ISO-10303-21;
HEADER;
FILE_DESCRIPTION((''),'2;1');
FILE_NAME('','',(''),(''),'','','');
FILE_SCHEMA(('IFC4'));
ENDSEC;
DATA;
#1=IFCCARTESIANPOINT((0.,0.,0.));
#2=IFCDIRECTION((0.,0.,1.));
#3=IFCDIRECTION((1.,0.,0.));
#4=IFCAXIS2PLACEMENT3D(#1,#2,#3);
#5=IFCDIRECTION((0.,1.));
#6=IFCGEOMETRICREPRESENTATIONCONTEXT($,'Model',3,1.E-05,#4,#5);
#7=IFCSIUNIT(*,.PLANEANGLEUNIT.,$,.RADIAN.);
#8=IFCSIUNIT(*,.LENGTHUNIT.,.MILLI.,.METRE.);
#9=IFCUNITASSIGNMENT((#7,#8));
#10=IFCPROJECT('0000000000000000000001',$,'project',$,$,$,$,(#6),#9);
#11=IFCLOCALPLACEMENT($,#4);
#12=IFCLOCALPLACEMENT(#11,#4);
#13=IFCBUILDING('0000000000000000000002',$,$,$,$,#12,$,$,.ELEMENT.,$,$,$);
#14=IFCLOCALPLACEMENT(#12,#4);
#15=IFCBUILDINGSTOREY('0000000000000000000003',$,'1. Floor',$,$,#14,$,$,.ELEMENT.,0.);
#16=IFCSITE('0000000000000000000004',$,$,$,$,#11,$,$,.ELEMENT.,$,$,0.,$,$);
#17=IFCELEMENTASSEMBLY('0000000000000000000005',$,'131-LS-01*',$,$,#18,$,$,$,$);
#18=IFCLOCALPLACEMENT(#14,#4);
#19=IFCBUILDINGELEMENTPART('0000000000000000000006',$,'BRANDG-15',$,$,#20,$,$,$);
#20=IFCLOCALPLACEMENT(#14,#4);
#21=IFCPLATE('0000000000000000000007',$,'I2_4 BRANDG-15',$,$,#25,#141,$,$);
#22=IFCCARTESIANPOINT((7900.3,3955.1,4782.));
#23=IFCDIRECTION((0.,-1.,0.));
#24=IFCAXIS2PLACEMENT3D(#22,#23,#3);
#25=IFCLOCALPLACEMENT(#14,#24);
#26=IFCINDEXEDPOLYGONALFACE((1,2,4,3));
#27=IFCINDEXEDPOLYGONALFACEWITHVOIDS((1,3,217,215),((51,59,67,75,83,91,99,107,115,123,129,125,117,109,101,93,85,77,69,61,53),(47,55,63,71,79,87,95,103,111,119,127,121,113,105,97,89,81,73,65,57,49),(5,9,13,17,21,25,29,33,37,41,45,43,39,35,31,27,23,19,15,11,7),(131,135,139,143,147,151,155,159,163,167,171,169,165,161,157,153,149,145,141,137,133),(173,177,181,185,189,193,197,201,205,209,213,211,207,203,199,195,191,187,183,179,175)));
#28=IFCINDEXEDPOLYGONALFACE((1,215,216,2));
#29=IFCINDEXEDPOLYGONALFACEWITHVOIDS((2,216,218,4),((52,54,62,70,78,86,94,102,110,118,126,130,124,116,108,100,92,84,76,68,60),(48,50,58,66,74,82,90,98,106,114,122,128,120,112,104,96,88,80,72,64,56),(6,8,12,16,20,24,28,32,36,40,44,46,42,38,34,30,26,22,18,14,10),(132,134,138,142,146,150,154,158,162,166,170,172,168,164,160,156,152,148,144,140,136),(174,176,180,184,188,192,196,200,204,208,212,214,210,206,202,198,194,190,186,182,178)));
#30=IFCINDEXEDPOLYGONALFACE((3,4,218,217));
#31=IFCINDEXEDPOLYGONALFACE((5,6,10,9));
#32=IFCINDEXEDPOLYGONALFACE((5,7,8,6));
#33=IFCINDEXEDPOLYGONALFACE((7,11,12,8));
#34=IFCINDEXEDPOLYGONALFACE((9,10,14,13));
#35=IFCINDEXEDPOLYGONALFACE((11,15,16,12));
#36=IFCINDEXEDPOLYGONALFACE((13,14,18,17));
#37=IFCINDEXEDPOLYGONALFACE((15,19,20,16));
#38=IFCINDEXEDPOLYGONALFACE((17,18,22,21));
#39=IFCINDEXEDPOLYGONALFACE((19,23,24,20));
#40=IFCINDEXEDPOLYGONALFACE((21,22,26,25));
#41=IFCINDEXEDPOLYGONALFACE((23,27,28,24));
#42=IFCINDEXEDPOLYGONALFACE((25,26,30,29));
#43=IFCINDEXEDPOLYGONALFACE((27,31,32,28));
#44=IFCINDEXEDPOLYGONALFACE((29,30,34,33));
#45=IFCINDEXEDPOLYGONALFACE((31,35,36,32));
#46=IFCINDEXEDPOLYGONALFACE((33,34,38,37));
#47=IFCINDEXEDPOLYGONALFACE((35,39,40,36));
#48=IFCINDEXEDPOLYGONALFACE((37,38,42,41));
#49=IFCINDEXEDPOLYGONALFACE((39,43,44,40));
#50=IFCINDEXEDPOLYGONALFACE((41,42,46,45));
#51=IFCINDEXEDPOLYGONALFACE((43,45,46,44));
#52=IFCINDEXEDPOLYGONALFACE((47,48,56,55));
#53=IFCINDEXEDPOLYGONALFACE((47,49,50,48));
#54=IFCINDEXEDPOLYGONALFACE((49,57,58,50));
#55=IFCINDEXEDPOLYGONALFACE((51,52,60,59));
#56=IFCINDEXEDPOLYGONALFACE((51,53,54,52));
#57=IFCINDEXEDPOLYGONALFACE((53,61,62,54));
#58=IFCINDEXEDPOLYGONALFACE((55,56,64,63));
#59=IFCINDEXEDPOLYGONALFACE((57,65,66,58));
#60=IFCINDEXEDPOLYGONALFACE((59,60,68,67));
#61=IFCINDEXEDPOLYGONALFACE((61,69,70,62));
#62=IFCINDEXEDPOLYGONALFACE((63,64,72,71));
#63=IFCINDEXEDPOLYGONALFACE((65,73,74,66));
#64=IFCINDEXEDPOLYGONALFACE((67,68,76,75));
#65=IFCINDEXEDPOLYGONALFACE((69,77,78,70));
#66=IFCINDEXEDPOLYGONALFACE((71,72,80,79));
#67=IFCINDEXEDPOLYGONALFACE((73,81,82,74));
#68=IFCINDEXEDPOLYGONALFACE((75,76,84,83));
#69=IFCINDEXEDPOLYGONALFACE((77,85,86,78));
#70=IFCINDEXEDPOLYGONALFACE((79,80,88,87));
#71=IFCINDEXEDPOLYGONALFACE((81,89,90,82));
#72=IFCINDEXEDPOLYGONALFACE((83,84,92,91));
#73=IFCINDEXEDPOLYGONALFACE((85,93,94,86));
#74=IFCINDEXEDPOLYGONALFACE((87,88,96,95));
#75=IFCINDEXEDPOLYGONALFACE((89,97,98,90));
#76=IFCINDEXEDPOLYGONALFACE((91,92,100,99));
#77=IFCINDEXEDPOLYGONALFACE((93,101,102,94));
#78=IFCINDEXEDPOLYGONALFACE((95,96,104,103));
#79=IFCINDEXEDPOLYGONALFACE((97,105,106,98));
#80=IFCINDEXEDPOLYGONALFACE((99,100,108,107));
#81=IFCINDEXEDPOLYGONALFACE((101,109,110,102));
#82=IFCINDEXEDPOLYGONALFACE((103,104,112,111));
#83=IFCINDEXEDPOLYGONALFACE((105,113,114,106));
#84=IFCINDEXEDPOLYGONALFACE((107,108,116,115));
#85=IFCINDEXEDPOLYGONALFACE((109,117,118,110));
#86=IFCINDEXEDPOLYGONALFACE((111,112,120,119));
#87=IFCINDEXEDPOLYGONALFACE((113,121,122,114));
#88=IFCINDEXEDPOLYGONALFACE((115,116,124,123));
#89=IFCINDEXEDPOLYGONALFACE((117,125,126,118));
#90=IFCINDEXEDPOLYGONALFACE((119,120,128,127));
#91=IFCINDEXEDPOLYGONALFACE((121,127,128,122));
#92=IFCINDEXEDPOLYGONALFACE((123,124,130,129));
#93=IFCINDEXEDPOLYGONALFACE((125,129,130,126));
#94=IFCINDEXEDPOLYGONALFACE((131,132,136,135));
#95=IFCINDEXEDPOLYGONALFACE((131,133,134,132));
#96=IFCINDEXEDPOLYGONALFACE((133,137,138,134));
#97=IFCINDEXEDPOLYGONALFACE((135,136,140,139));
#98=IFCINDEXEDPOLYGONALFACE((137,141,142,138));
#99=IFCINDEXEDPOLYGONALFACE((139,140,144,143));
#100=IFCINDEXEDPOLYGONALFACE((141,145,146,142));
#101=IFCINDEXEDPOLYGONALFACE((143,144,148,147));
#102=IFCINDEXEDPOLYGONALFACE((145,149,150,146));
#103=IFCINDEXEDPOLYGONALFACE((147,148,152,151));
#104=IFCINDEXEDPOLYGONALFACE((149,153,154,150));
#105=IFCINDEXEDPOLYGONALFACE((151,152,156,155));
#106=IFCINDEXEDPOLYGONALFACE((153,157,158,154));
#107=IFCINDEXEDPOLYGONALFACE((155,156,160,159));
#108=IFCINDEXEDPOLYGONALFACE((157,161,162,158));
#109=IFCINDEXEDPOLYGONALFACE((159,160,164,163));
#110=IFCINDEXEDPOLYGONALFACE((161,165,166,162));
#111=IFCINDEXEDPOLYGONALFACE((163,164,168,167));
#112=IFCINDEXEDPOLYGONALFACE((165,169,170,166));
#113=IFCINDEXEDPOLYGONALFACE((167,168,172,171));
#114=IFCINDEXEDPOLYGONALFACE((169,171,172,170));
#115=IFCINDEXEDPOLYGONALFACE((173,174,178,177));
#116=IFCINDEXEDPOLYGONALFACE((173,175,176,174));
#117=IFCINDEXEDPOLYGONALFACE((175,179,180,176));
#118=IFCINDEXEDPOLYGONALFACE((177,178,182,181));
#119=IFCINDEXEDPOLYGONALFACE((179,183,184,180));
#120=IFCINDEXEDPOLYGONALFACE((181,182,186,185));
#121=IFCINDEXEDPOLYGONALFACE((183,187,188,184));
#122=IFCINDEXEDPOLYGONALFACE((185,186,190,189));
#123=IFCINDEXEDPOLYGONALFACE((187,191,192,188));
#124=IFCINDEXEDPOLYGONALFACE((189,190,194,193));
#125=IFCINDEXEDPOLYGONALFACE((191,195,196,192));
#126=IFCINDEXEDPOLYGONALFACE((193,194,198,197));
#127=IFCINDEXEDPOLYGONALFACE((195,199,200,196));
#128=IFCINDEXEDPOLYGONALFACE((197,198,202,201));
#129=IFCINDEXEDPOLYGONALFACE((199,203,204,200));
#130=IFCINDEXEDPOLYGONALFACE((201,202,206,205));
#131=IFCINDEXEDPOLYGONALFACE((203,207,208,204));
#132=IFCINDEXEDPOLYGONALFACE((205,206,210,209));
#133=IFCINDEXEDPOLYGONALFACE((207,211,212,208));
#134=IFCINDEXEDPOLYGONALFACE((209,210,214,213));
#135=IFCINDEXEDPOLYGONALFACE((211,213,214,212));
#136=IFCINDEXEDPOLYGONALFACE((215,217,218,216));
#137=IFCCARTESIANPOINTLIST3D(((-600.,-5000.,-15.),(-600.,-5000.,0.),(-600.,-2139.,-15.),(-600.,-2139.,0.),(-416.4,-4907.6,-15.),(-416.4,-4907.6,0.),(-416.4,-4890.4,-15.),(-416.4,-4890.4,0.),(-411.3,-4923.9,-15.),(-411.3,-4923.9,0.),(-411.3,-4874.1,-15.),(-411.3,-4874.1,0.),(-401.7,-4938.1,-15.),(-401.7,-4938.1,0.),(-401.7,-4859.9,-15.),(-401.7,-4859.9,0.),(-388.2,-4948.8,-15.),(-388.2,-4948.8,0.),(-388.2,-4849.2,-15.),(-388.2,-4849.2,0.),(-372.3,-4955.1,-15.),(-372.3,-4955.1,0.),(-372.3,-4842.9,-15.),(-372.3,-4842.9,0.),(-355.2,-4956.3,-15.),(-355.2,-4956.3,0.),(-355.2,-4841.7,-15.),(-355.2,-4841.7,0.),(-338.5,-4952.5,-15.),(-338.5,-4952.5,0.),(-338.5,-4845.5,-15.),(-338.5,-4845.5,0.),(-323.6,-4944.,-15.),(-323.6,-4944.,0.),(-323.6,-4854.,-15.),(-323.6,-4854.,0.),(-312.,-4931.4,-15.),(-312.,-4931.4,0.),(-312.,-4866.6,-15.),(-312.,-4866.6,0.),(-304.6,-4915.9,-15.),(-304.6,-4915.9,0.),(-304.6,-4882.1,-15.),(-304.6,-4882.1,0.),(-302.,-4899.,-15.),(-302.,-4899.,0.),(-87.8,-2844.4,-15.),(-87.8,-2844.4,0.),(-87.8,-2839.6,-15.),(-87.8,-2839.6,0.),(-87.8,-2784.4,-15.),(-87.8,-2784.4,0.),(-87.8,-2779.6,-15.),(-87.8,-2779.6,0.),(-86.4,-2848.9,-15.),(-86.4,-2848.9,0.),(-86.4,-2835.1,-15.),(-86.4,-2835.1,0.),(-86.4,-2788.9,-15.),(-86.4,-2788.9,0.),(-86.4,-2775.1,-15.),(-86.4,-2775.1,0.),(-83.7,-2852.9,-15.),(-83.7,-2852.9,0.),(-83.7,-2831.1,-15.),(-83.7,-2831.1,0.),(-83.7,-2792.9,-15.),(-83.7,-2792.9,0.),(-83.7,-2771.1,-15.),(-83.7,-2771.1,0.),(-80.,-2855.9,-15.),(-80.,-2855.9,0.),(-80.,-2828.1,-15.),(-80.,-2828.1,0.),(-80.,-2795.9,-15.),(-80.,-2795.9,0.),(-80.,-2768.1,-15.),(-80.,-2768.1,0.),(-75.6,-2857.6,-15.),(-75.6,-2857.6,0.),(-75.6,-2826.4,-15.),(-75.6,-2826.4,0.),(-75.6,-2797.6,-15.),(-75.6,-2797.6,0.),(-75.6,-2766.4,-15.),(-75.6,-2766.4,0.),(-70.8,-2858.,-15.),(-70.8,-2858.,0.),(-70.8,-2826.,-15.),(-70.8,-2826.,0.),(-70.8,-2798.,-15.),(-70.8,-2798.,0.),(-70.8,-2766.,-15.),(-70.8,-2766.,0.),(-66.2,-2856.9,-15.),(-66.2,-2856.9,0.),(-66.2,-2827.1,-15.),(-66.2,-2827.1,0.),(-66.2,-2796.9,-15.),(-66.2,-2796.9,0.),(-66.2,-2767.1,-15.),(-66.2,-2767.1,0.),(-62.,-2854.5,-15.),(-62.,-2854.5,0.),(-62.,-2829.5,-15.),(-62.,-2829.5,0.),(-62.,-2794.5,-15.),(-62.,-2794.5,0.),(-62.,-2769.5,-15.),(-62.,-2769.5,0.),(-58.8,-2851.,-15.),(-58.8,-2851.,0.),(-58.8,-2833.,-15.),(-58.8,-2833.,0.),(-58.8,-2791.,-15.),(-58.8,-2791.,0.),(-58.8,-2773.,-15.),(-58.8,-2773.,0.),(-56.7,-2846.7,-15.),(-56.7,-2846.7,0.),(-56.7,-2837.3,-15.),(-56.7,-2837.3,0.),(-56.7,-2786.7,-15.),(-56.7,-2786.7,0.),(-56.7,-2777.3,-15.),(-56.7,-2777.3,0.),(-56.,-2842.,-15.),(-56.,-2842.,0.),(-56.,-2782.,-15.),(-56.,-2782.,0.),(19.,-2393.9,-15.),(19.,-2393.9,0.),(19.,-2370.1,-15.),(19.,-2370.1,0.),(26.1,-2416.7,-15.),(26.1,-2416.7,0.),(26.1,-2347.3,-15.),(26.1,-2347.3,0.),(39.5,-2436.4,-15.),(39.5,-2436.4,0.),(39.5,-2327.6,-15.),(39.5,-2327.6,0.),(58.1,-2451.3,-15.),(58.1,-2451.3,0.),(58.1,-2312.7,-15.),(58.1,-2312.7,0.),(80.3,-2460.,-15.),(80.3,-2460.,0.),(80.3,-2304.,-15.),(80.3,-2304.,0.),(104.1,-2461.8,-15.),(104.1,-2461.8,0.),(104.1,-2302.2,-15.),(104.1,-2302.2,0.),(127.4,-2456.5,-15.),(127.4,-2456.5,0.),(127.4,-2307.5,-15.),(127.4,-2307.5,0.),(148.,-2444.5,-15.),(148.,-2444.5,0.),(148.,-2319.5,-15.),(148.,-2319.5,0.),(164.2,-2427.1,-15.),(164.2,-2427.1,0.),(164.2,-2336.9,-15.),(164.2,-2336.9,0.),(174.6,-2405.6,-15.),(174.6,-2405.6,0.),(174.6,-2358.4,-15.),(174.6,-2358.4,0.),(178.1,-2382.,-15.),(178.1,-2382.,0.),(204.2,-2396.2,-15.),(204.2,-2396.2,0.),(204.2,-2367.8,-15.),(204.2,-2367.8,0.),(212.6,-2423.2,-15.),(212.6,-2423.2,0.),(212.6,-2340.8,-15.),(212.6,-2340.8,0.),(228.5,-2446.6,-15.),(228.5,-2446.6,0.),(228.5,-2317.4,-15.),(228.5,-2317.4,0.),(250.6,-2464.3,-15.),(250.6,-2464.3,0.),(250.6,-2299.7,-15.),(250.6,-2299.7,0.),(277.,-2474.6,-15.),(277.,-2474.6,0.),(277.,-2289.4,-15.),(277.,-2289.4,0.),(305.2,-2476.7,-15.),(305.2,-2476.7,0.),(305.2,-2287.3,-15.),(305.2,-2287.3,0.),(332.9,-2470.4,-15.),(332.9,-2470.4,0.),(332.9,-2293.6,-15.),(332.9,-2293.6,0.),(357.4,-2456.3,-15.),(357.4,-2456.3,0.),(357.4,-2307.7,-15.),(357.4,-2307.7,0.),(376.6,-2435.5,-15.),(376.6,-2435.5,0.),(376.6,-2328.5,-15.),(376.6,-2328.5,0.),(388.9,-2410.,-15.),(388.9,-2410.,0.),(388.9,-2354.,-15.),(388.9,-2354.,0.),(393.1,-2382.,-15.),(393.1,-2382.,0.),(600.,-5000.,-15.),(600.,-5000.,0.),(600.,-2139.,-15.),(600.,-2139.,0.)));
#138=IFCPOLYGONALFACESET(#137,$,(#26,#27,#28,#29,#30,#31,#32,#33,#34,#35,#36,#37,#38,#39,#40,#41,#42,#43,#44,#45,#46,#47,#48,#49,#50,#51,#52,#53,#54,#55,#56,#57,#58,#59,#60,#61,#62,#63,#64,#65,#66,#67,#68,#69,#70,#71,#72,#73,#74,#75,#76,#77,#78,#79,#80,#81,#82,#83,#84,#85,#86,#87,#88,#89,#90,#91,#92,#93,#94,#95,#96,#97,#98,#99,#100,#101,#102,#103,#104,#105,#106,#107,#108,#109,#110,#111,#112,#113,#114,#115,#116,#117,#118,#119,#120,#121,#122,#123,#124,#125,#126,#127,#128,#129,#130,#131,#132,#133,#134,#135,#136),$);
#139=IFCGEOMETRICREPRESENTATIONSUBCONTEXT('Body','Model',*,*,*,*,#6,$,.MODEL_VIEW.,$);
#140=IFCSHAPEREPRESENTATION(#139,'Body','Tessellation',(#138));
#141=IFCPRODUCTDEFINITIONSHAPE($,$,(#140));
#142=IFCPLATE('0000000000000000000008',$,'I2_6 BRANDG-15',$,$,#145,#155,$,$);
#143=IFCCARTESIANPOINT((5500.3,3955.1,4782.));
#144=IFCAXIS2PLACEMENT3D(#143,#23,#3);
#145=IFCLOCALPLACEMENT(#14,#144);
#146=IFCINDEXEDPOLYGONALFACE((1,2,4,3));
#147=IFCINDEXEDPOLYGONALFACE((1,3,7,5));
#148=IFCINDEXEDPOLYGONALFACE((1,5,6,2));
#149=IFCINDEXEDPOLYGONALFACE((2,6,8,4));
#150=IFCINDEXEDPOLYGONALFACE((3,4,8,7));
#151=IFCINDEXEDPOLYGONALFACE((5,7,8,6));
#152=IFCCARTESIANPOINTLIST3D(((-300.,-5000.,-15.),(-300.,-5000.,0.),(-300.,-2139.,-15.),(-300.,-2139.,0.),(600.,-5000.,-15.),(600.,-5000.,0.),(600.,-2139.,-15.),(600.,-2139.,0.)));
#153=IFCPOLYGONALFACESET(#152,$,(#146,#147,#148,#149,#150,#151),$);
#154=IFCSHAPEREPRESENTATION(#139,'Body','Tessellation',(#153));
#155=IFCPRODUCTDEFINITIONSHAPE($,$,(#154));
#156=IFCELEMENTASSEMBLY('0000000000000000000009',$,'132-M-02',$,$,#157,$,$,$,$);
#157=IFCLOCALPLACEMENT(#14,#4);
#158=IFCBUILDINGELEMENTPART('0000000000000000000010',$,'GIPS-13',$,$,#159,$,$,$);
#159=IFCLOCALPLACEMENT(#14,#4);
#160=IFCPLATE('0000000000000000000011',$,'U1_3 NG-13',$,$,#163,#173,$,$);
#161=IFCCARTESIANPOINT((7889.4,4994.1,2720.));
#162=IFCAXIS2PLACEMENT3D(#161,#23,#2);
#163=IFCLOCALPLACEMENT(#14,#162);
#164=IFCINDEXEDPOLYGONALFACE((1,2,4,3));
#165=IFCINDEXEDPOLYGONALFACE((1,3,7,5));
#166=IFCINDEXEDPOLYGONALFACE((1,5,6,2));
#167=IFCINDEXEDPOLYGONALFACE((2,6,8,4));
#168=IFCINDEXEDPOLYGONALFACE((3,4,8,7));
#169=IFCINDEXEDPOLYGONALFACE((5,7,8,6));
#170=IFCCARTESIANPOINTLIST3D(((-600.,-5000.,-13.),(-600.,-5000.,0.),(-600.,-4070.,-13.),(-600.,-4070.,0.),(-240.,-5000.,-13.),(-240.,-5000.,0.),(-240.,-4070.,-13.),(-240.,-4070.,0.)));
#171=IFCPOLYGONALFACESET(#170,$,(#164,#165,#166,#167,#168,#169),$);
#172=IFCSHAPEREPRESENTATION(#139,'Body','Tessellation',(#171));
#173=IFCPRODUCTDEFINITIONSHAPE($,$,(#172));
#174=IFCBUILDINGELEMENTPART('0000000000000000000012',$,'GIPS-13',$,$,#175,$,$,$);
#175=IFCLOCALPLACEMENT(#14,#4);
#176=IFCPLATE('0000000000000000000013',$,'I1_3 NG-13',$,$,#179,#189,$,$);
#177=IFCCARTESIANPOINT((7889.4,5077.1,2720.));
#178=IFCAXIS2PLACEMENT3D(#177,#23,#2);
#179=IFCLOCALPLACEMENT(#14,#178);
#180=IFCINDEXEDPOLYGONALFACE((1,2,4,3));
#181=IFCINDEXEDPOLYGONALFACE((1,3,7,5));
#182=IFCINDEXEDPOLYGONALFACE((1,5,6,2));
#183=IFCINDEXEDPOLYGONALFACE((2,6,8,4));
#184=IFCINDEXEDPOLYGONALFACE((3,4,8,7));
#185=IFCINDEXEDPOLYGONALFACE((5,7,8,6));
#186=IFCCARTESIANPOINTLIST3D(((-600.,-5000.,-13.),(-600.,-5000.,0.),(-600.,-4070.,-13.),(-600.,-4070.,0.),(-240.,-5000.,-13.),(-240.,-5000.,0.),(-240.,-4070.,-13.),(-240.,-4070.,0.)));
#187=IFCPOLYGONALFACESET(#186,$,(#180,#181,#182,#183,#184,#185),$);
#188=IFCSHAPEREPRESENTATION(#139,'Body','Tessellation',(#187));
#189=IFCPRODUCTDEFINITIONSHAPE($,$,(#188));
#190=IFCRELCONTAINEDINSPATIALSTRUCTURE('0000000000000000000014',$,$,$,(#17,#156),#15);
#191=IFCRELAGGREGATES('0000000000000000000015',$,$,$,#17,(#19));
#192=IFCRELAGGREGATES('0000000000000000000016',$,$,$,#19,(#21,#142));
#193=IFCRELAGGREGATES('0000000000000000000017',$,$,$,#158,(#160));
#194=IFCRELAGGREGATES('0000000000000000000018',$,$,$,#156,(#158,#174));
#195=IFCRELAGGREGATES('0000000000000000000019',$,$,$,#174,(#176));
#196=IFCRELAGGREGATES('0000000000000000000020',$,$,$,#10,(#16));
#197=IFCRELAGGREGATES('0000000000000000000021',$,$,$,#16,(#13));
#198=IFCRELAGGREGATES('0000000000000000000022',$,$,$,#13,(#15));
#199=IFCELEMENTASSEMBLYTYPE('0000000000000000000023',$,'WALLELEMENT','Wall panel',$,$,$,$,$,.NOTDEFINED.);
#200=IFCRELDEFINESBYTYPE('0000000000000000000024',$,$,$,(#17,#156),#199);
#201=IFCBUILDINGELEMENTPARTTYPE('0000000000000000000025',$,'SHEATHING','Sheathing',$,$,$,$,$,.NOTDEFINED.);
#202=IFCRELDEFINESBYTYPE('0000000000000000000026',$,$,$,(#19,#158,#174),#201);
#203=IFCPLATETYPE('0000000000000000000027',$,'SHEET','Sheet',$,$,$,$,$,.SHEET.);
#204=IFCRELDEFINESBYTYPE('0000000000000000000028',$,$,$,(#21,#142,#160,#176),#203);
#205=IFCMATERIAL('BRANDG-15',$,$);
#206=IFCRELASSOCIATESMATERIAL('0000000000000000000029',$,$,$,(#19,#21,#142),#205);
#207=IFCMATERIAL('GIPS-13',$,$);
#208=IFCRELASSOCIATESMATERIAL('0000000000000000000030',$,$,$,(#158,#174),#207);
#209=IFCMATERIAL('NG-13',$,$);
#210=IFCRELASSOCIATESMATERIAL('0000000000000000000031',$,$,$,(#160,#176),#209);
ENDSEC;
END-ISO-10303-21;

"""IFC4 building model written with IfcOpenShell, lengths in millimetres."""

from ifc_helpers import new_model, si_unit, direction, frame, origin_with_axes, origin_2d_with_axis, place, context, subcontext, project, spatial, rectangle, circle, extrude, boolean, material, type_object, element, aggregate, save


model = new_model("IFC4")

# Units and contexts
model_context = context("Model", 3, precision=1e-05, world=origin_with_axes(), true_north=direction((0.0, 1.0)))
body_context = subcontext(model_context, "Body", "Model", "MODEL_VIEW")
ifc_project = project(units=[si_unit("PLANEANGLEUNIT", "RADIAN"), si_unit("LENGTHUNIT", "METRE", prefix="MILLI")], contexts=[model_context])

# Site, building, storey
site_placement = place(None, origin_with_axes())
site = spatial("IfcSite", under=ifc_project, at=site_placement, CompositionType="ELEMENT", RefElevation=0.0)
building_placement = place(site_placement, origin_with_axes())
building = spatial("IfcBuilding", under=site, at=building_placement, CompositionType="ELEMENT")
storey_placement = place(building_placement, origin_with_axes())
storey = spatial("IfcBuildingStorey", under=building, at=storey_placement, Name="1. Floor", CompositionType="ELEMENT", Elevation=0.0)

# Element assemblies, building element parts, plates
element_assembly_type_1 = type_object("IfcElementAssemblyType", Name="WALLELEMENT", Description="Wall panel", PredefinedType="NOTDEFINED")
assembly_1_placement = place(storey_placement, origin_with_axes())
assembly_1 = element("IfcElementAssembly", 1, at=assembly_1_placement, inside=storey, type_object=element_assembly_type_1, Name="131-LS-01*")
ifc_material_1 = material(Name="BRANDG-15")
building_element_part_type_1 = type_object("IfcBuildingElementPartType", Name="SHEATHING", Description="Sheathing", PredefinedType="NOTDEFINED")
plate_type_1 = type_object("IfcPlateType", Name="SHEET", Description="Sheet", PredefinedType="SHEET")
building_element_part_1_placement = place(storey_placement, origin_with_axes())
building_element_part_1 = element("IfcBuildingElementPart", 2, at=building_element_part_1_placement, type_object=building_element_part_type_1, material=ifc_material_1, Name="BRANDG-15")
aggregate(assembly_1, [building_element_part_1])
plate_1_placement = place(storey_placement, frame((7900.3, 3955.1, 4782.0), z_axis=(0.0, -1.0, 0.0), x_axis=(1.0, 0.0, 0.0)))
solid = boolean("DIFFERENCE", boolean("DIFFERENCE", boolean("DIFFERENCE", boolean("DIFFERENCE", boolean("DIFFERENCE", boolean("DIFFERENCE", boolean("DIFFERENCE", boolean("DIFFERENCE", extrude(rectangle(XDim=15.0, YDim=1200.0, at=origin_2d_with_axis()), frame((0.0, -5000.0, -7.5), z_axis=(0.0, 1.0, 0.0), x_axis=(0.0, 0.0, 1.0)), (0.0, 0.0, 1.0), 2861.0), extrude(circle(Radius=16.0, at=origin_2d_with_axis()), frame((-72.0, -2842.0, -16.0), z_axis=(0.0, 0.0, -1.0), x_axis=(1.0, 0.0, 0.0)), (0.0, 0.0, -1.0), 64.5)), extrude(circle(Radius=57.5, at=origin_2d_with_axis()), frame((-359.5, -4899.0, -16.0), z_axis=(0.0, 0.0, -1.0), x_axis=(1.0, 0.0, 0.0)), (0.0, 0.0, -1.0), 64.5)), extrude(circle(Radius=65.0, at=origin_2d_with_axis()), frame((98.1, -2382.0, -16.0), z_axis=(0.0, 0.0, -1.0), x_axis=(1.0, 0.0, 0.0)), (0.0, 0.0, -1.0), 64.5)), extrude(circle(Radius=80.0, at=origin_2d_with_axis()), frame((98.1, -2382.0, -16.0), z_axis=(0.0, 0.0, -1.0), x_axis=(1.0, 0.0, 0.0)), (0.0, 0.0, -1.0), 17.0)), extrude(circle(Radius=80.0, at=origin_2d_with_axis()), frame((298.1, -2382.0, -16.0), z_axis=(0.0, 0.0, -1.0), x_axis=(1.0, 0.0, 0.0)), (0.0, 0.0, -1.0), 64.5)), extrude(circle(Radius=95.0, at=origin_2d_with_axis()), frame((298.1, -2382.0, -16.0), z_axis=(0.0, 0.0, -1.0), x_axis=(1.0, 0.0, 0.0)), (0.0, 0.0, -1.0), 17.0)), extrude(circle(Radius=16.0, at=origin_2d_with_axis()), frame((-72.0, -2782.0, -16.0), z_axis=(0.0, 0.0, -1.0), x_axis=(1.0, 0.0, 0.0)), (0.0, 0.0, -1.0), 64.5)), extrude(circle(Radius=57.5, at=origin_2d_with_axis()), frame((-359.5, -4899.0, -16.0), z_axis=(0.0, 0.0, -1.0), x_axis=(1.0, 0.0, 0.0)), (0.0, 0.0, -1.0), 64.5))
plate_1 = element("IfcPlate", 3, at=plate_1_placement, type_object=plate_type_1, material=ifc_material_1, Name="I2_4 BRANDG-15", context=body_context, shape_type="CSG", body=[
    boolean("DIFFERENCE", boolean("DIFFERENCE", boolean("DIFFERENCE", boolean("DIFFERENCE", solid, extrude(circle(Radius=16.0, at=origin_2d_with_axis()), frame((-72.0, -2782.0, -16.0), z_axis=(0.0, 0.0, -1.0), x_axis=(1.0, 0.0, 0.0)), (0.0, 0.0, -1.0), 64.5)), extrude(circle(Radius=16.0, at=origin_2d_with_axis()), frame((-72.0, -2842.0, -16.0), z_axis=(0.0, 0.0, -1.0), x_axis=(1.0, 0.0, 0.0)), (0.0, 0.0, -1.0), 64.5)), extrude(circle(Radius=15.0, at=origin_2d_with_axis()), frame((-339.5, -4899.0, -14.0), z_axis=(0.0, 0.0, 1.0), x_axis=(-1.0, 0.0, 0.0)), (0.0, 0.0, -1.0), 102.0)), extrude(circle(Radius=15.0, at=origin_2d_with_axis()), frame((-379.5, -4899.0, -14.0), z_axis=(0.0, 0.0, 1.0), x_axis=(-1.0, 0.0, 0.0)), (0.0, 0.0, -1.0), 102.0)),
])
plate_2_placement = place(storey_placement, frame((5500.3, 3955.1, 4782.0), z_axis=(0.0, -1.0, 0.0), x_axis=(1.0, 0.0, 0.0)))
plate_2 = element("IfcPlate", 4, at=plate_2_placement, type_object=plate_type_1, material=ifc_material_1, Name="I2_6 BRANDG-15", context=body_context, shape_type="SweptSolid", body=[
    extrude(rectangle(XDim=15.0, YDim=900.0, at=origin_2d_with_axis()), frame((150.0, -5000.0, -7.5), z_axis=(0.0, 1.0, 0.0), x_axis=(0.0, 0.0, 1.0)), (0.0, 0.0, 1.0), 2861.0),
])
aggregate(building_element_part_1, [plate_1, plate_2])
assembly_2_placement = place(storey_placement, origin_with_axes())
assembly_2 = element("IfcElementAssembly", 5, at=assembly_2_placement, inside=storey, type_object=element_assembly_type_1, Name="132-M-02")
ifc_material_2 = material(Name="GIPS-13")
building_element_part_2_placement = place(storey_placement, origin_with_axes())
building_element_part_2 = element("IfcBuildingElementPart", 6, at=building_element_part_2_placement, type_object=building_element_part_type_1, material=ifc_material_2, Name="GIPS-13")
ifc_material_3 = material(Name="NG-13")
plate_3_placement = place(storey_placement, frame((7889.4, 4994.1, 2720.0), z_axis=(0.0, -1.0, 0.0), x_axis=(0.0, 0.0, 1.0)))
plate_3 = element("IfcPlate", 7, at=plate_3_placement, type_object=plate_type_1, material=ifc_material_3, Name="U1_3 NG-13", context=body_context, shape_type="SweptSolid", body=[
    extrude(rectangle(XDim=13.0, YDim=360.0, at=origin_2d_with_axis()), frame((-420.0, -5000.0, -6.5), z_axis=(0.0, 1.0, 0.0), x_axis=(0.0, 0.0, 1.0)), (0.0, 0.0, 1.0), 930.0),
])
aggregate(building_element_part_2, [plate_3])
building_element_part_3_placement = place(storey_placement, origin_with_axes())
building_element_part_3 = element("IfcBuildingElementPart", 8, at=building_element_part_3_placement, type_object=building_element_part_type_1, material=ifc_material_2, Name="GIPS-13")
aggregate(assembly_2, [building_element_part_2, building_element_part_3])
plate_4_placement = place(storey_placement, frame((7889.4, 5077.1, 2720.0), z_axis=(0.0, -1.0, 0.0), x_axis=(0.0, 0.0, 1.0)))
plate_4 = element("IfcPlate", 9, at=plate_4_placement, type_object=plate_type_1, material=ifc_material_3, Name="I1_3 NG-13", context=body_context, shape_type="SweptSolid", body=[
    extrude(rectangle(XDim=13.0, YDim=360.0, at=origin_2d_with_axis()), frame((-420.0, -5000.0, -6.5), z_axis=(0.0, 1.0, 0.0), x_axis=(0.0, 0.0, 1.0)), (0.0, 0.0, 1.0), 930.0),
])
aggregate(building_element_part_3, [plate_4])

save(model, "model.ifc")
